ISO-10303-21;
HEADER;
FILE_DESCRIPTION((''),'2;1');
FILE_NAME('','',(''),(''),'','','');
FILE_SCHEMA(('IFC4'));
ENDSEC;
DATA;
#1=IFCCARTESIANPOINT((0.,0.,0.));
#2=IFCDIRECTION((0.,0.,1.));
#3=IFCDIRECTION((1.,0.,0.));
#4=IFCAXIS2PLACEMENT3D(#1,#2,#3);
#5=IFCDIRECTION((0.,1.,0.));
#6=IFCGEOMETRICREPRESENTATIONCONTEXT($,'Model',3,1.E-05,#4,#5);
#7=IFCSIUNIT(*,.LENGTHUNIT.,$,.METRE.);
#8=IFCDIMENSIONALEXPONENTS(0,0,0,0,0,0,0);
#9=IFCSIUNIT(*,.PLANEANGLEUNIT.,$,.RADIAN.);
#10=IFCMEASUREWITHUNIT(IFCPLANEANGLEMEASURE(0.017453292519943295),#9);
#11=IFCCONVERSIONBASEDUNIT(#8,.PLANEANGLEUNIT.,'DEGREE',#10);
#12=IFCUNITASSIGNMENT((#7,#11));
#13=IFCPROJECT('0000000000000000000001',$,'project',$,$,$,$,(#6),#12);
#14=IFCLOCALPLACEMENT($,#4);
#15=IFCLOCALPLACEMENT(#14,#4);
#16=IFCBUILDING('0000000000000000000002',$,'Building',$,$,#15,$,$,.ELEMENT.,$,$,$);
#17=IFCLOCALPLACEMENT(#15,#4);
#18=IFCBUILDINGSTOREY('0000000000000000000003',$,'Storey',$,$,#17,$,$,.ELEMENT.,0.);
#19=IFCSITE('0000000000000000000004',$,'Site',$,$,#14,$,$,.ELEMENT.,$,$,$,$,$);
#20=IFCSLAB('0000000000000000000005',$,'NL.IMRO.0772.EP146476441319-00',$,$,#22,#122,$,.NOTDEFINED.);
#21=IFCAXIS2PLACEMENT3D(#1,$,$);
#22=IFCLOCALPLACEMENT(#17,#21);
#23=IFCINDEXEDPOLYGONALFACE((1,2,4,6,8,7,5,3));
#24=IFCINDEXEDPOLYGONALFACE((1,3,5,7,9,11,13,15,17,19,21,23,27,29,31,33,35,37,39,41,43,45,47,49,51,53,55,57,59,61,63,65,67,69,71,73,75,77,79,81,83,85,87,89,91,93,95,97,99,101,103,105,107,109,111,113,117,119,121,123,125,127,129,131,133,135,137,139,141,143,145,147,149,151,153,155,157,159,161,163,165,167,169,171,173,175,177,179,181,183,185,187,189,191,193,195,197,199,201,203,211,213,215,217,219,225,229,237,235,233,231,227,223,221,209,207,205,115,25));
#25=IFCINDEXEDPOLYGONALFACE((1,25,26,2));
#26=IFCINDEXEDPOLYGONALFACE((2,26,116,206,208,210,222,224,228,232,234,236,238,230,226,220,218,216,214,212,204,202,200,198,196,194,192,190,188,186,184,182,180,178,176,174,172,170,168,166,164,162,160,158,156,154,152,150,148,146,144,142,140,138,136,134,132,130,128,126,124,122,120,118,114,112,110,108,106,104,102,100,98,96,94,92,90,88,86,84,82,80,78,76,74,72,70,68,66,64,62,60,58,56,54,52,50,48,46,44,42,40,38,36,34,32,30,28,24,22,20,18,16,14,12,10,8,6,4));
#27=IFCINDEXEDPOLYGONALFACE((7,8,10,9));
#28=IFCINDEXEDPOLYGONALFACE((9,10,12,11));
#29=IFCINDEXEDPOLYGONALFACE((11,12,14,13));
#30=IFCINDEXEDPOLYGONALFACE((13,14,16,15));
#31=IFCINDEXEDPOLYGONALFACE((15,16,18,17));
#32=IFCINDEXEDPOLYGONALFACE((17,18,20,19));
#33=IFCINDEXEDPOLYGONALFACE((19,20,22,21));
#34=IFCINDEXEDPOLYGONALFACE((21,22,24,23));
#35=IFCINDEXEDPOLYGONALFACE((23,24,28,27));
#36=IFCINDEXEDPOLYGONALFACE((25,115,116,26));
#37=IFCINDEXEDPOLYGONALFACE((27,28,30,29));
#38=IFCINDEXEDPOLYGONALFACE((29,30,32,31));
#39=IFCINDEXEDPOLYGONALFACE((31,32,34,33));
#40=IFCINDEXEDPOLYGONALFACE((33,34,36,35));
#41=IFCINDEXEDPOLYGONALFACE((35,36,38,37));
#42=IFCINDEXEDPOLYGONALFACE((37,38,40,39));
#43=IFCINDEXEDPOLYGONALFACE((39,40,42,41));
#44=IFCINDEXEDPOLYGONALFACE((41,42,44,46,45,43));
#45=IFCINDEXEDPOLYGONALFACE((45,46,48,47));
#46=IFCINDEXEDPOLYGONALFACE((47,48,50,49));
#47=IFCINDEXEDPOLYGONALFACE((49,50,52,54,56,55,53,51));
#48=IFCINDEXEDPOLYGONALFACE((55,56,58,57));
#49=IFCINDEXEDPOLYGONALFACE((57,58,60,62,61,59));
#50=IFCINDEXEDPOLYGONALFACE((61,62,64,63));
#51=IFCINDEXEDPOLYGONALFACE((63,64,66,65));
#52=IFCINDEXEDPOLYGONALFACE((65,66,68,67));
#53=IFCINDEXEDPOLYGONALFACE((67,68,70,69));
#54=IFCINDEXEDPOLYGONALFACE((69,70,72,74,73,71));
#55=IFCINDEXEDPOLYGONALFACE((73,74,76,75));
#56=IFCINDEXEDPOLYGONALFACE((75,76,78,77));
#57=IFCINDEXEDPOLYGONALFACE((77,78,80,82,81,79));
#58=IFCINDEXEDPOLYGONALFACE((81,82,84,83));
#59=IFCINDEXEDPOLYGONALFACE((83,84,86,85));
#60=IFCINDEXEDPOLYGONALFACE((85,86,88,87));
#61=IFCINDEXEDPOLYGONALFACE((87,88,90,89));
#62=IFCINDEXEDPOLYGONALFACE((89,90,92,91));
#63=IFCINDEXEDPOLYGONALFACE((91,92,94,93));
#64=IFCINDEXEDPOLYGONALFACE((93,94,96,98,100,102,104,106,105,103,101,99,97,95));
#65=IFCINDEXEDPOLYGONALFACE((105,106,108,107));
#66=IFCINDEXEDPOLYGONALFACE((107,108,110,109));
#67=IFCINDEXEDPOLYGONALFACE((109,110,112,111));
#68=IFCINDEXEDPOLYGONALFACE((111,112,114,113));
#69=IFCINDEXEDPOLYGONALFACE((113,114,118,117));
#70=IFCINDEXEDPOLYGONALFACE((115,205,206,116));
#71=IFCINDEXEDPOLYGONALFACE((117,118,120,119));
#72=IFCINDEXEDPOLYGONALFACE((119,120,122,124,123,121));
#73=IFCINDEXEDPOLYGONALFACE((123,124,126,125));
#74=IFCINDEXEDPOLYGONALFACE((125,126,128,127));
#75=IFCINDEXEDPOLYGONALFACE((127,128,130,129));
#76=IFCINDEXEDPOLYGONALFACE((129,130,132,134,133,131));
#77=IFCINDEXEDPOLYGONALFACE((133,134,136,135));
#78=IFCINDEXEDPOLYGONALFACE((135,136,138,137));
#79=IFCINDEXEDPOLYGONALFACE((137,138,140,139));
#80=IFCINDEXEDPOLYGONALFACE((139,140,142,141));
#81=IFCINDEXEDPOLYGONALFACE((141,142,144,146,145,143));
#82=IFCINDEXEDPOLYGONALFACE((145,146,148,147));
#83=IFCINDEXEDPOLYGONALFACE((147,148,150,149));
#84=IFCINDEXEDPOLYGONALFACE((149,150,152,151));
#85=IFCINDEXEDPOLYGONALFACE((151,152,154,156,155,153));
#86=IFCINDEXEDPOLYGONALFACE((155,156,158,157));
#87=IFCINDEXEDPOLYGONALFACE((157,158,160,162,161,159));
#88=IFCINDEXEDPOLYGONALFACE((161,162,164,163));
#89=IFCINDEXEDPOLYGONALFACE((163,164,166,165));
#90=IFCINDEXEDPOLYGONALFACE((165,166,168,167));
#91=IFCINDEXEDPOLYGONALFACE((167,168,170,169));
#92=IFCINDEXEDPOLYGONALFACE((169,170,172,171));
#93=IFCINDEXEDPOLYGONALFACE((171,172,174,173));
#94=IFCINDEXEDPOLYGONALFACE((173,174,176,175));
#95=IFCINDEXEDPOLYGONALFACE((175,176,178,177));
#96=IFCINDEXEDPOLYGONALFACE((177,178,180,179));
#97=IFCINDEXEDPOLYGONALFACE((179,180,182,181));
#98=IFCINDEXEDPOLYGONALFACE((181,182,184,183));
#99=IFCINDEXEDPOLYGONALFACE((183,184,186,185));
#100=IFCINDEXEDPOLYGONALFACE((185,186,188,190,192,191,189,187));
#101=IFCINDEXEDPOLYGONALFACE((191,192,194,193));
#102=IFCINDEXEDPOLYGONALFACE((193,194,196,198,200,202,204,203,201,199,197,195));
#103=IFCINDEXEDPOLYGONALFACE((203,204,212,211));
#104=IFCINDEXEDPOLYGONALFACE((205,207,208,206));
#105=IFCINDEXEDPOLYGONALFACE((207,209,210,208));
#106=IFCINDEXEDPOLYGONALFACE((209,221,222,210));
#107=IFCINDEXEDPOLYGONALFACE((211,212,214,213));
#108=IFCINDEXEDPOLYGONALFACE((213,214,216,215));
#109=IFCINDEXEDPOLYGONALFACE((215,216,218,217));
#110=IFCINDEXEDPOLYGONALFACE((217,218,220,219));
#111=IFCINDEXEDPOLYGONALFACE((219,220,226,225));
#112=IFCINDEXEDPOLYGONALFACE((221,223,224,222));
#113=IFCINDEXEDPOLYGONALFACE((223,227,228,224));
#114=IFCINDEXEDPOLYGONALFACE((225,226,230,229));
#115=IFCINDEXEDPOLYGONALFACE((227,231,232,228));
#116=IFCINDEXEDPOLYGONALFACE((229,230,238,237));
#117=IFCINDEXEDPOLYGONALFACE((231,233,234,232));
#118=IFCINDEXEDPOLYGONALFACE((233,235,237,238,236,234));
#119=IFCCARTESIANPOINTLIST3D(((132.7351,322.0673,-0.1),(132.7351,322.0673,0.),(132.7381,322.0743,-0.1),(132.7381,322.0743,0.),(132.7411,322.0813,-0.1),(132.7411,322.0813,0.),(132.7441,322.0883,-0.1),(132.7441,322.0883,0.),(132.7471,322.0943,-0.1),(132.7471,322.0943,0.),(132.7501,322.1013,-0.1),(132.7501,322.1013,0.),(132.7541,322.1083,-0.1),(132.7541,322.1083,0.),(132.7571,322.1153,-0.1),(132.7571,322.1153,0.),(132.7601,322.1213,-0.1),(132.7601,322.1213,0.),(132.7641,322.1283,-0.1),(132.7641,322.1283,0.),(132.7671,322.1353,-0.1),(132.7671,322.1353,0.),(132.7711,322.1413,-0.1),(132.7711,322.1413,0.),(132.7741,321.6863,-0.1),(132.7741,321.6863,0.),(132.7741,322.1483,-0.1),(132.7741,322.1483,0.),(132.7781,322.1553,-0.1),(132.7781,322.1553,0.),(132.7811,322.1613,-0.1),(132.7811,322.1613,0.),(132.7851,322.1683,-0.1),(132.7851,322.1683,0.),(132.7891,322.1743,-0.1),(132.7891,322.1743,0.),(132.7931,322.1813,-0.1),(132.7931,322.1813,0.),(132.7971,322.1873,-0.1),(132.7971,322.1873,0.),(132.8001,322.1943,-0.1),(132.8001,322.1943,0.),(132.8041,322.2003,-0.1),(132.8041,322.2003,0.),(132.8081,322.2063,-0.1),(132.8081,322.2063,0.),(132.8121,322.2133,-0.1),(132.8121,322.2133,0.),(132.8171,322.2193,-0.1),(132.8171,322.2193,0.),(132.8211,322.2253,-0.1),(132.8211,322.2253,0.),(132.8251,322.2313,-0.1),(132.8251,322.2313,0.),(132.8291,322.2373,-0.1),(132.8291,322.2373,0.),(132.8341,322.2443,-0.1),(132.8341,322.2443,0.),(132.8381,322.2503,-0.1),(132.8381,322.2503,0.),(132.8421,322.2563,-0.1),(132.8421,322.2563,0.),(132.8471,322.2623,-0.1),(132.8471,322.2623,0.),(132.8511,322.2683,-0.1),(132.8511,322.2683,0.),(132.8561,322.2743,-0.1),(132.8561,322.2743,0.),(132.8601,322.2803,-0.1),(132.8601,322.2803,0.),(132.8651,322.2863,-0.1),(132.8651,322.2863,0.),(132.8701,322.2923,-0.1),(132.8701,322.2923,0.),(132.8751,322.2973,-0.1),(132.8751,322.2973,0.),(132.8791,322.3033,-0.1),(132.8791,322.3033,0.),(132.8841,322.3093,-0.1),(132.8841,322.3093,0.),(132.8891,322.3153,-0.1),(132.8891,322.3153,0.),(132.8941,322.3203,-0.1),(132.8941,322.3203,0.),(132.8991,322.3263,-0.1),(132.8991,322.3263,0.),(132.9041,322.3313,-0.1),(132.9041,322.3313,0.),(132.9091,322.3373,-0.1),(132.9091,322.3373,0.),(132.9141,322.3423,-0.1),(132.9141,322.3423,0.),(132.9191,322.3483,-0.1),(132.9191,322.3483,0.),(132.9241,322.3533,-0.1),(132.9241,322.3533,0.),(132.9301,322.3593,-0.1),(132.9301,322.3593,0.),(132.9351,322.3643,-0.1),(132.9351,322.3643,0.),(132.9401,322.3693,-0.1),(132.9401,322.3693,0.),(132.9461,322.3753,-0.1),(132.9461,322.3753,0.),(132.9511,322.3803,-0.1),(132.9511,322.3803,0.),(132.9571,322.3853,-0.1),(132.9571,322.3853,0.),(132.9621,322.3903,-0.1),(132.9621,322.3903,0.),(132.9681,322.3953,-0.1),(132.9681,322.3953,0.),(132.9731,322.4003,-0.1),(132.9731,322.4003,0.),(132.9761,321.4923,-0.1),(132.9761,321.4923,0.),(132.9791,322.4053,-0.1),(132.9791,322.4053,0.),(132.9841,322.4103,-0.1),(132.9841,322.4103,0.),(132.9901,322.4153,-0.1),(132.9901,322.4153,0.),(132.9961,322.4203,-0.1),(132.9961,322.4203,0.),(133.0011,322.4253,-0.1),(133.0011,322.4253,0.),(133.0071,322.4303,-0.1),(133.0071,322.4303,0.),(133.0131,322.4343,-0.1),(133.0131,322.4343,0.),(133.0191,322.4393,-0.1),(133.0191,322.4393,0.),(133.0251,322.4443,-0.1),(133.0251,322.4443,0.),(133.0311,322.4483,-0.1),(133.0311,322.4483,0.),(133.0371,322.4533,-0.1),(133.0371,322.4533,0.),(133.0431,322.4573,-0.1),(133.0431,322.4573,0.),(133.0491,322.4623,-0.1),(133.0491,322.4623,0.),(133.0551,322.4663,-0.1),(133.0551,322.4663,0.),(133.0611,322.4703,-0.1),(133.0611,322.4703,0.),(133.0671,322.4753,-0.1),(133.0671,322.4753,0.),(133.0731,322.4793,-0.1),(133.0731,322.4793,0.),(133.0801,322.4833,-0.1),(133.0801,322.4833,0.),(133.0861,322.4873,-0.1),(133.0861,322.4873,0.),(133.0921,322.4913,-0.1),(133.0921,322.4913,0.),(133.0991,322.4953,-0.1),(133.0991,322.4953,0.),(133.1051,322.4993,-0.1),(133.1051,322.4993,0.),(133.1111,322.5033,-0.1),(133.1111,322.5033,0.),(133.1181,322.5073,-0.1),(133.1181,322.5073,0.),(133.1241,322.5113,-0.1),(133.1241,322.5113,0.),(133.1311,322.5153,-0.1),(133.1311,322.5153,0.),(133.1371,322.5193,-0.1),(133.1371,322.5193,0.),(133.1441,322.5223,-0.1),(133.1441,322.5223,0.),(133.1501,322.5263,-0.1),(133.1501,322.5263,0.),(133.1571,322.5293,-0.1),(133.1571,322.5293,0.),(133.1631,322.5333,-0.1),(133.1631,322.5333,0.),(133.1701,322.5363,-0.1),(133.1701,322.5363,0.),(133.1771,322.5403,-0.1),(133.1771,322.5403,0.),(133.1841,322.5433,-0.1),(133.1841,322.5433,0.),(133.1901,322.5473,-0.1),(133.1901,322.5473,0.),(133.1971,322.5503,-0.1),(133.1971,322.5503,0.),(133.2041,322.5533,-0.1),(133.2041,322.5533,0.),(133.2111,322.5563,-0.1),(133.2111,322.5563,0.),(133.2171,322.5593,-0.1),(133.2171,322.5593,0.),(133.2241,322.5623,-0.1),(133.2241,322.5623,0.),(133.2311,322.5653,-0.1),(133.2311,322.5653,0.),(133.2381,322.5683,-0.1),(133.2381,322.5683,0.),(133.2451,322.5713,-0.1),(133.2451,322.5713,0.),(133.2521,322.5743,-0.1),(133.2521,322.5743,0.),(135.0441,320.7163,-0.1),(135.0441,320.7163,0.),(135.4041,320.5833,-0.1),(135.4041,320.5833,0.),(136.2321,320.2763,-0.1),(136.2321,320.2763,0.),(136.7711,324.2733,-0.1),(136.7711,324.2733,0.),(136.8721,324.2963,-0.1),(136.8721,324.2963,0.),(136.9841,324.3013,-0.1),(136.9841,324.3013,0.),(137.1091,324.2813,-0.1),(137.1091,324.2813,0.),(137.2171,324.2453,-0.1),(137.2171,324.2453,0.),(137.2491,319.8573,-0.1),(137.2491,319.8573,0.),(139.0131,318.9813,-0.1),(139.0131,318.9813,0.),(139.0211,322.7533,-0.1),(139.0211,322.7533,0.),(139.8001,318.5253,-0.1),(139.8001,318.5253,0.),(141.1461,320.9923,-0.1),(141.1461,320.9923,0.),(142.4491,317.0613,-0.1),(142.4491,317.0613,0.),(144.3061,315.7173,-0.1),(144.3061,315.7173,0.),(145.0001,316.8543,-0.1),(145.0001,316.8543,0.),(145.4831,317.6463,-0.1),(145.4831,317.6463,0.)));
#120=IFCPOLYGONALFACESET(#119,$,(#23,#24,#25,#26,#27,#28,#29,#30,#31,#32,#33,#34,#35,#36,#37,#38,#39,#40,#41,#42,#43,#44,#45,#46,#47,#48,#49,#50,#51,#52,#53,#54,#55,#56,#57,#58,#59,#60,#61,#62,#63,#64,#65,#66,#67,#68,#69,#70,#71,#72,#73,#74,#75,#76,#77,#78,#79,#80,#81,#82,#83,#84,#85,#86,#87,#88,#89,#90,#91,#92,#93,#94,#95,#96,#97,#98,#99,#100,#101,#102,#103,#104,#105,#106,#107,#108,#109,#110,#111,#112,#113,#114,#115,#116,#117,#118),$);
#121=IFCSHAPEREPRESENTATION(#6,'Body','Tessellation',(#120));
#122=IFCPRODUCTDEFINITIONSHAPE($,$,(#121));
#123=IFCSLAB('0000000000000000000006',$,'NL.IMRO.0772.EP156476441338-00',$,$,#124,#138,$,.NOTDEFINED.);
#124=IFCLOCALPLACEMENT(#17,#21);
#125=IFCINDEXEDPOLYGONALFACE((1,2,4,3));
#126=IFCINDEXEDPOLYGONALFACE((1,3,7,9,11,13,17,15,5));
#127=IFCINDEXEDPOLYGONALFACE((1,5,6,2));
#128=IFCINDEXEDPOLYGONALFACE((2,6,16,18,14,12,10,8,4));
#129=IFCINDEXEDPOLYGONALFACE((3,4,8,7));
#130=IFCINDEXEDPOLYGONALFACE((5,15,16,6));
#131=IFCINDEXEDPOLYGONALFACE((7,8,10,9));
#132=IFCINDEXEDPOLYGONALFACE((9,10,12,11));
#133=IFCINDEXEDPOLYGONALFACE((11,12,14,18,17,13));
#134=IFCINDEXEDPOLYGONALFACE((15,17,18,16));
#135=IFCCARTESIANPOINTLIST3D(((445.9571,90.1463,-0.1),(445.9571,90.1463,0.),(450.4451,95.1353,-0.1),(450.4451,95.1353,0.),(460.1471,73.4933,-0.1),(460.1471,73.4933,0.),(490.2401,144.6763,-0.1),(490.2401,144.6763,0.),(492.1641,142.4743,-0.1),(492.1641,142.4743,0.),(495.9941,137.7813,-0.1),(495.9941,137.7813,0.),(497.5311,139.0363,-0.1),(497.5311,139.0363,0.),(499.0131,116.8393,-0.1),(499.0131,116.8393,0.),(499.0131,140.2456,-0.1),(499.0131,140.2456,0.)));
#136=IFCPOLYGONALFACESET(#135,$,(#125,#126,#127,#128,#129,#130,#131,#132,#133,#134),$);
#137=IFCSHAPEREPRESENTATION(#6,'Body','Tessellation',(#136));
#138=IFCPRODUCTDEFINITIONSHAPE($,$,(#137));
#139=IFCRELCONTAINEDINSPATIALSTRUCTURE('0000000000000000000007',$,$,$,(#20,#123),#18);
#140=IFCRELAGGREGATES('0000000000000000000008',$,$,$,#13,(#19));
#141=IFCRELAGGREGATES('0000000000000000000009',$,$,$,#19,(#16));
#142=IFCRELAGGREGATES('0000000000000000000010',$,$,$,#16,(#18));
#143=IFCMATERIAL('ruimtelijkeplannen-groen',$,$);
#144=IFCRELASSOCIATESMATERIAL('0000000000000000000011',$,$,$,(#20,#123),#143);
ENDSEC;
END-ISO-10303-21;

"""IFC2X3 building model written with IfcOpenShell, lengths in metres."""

from ifc_helpers import new_model, entity, si_unit, converted_unit, direction, frame, origin_with_axes, place, context, project, spatial, polyline, outline, extrude, material, element, save


model = new_model("IFC2X3")

# Units and contexts
model_context = context("Model", 3, precision=1e-05, world=origin_with_axes(), true_north=direction((0.0, 1.0, 0.0)))
ifc_project = project(units=[si_unit("LENGTHUNIT", "METRE"), converted_unit("PLANEANGLEUNIT", "DEGREE", entity("IfcPlaneAngleMeasure", 0.017453292519943295), si_unit("PLANEANGLEUNIT", "RADIAN"), dimensions=[0, 0, 0, 0, 0, 0, 0])], contexts=[model_context])

# Site, building, storey
site_placement = place(None, origin_with_axes())
site = spatial("IfcSite", under=ifc_project, at=site_placement, Name="Site", CompositionType="ELEMENT")
building_placement = place(site_placement, origin_with_axes())
building = spatial("IfcBuilding", under=site, at=building_placement, Name="Building", CompositionType="ELEMENT")
storey_placement = place(building_placement, origin_with_axes())
storey = spatial("IfcBuildingStorey", under=building, at=storey_placement, Name="Storey", CompositionType="ELEMENT", Elevation=0.0)

# Slabs
ifc_material_1 = material(Name="ruimtelijkeplannen-groen")
slab_1_placement = place(storey_placement, frame((0.0, 0.0, -0.1), z_axis=(0.0, 0.0, 1.0), x_axis=(1.0, 0.0, 0.0)))
element("IfcSlab", 1, at=slab_1_placement, inside=storey, material=ifc_material_1, Name="NL.IMRO.0772.EP146476441319-00", PredefinedType="NOTDEFINED", context=model_context, shape_type="SweptSolid", body=[
    extrude(outline(polyline([(136.7711, 324.2733), (136.8721, 324.2963), (136.9841, 324.3013), (137.1091, 324.2813), (137.2171, 324.2453), (139.0211, 322.7533), (141.1461, 320.9923), (145.4831, 317.6463), (145.0001, 316.8543), (144.3061, 315.7173), (142.4491, 317.0613), (139.8001, 318.5253), (139.0131, 318.9813), (137.2491, 319.8573), (136.2321, 320.2763), (135.4041, 320.5833), (135.0441, 320.7163), (132.9761, 321.4923), (132.7741, 321.6863), (132.7351, 322.0673), (132.7381, 322.0743), (132.7411, 322.0813), (132.7441, 322.0883), (132.7471, 322.0943), (132.7501, 322.1013), (132.7541, 322.1083), (132.7571, 322.1153), (132.7601, 322.1213), (132.7641, 322.1283), (132.7671, 322.1353), (132.7711, 322.1413), (132.7741, 322.1483), (132.7781, 322.1553), (132.7811, 322.1613), (132.7851, 322.1683), (132.7891, 322.1743), (132.7931, 322.1813), (132.7971, 322.1873), (132.8001, 322.1943), (132.8041, 322.2003), (132.8081, 322.2063), (132.8121, 322.2133), (132.8171, 322.2193), (132.8211, 322.2253), (132.8251, 322.2313), (132.8291, 322.2373), (132.8341, 322.2443), (132.8381, 322.2503), (132.8421, 322.2563), (132.8471, 322.2623), (132.8511, 322.2683), (132.8561, 322.2743), (132.8601, 322.2803), (132.8651, 322.2863), (132.8701, 322.2923), (132.8751, 322.2973), (132.8791, 322.3033), (132.8841, 322.3093), (132.8891, 322.3153), (132.8941, 322.3203), (132.8991, 322.3263), (132.9041, 322.3313), (132.9091, 322.3373), (132.9141, 322.3423), (132.9191, 322.3483), (132.9241, 322.3533), (132.9301, 322.3593), (132.9351, 322.3643), (132.9401, 322.3693), (132.9461, 322.3753), (132.9511, 322.3803), (132.9571, 322.3853), (132.9621, 322.3903), (132.9681, 322.3953), (132.9731, 322.4003), (132.9791, 322.4053), (132.9841, 322.4103), (132.9901, 322.4153), (132.9961, 322.4203), (133.0011, 322.4253), (133.0071, 322.4303), (133.0131, 322.4343), (133.0191, 322.4393), (133.0251, 322.4443), (133.0311, 322.4483), (133.0371, 322.4533), (133.0431, 322.4573), (133.0491, 322.4623), (133.0551, 322.4663), (133.0611, 322.4703), (133.0671, 322.4753), (133.0731, 322.4793), (133.0801, 322.4833), (133.0861, 322.4873), (133.0921, 322.4913), (133.0991, 322.4953), (133.1051, 322.4993), (133.1111, 322.5033), (133.1181, 322.5073), (133.1241, 322.5113), (133.1311, 322.5153), (133.1371, 322.5193), (133.1441, 322.5223), (133.1501, 322.5263), (133.1571, 322.5293), (133.1631, 322.5333), (133.1701, 322.5363), (133.1771, 322.5403), (133.1841, 322.5433), (133.1901, 322.5473), (133.1971, 322.5503), (133.2041, 322.5533), (133.2111, 322.5563), (133.2171, 322.5593), (133.2241, 322.5623), (133.2311, 322.5653), (133.2381, 322.5683), (133.2451, 322.5713), (133.2521, 322.5743), (136.7711, 324.2733)])), origin_with_axes(), (0.0, 0.0, 1.0), 0.1),
])
slab_2_placement = place(storey_placement, frame((0.0, 0.0, -0.1), z_axis=(0.0, 0.0, 1.0), x_axis=(1.0, 0.0, 0.0)))
element("IfcSlab", 2, at=slab_2_placement, inside=storey, material=ifc_material_1, Name="NL.IMRO.0772.EP156476441338-00", PredefinedType="NOTDEFINED", context=model_context, shape_type="SweptSolid", body=[
    extrude(outline(polyline([(460.1471, 73.4933), (445.9571, 90.1463), (450.4451, 95.1353), (490.2401, 144.6763), (492.1641, 142.4743), (495.9941, 137.7813), (497.5311, 139.0363), (499.0131, 140.2456), (499.0131, 116.8393), (460.1471, 73.4933)])), origin_with_axes(), (0.0, 0.0, 1.0), 0.1),
])

save(model, "model.ifc")
